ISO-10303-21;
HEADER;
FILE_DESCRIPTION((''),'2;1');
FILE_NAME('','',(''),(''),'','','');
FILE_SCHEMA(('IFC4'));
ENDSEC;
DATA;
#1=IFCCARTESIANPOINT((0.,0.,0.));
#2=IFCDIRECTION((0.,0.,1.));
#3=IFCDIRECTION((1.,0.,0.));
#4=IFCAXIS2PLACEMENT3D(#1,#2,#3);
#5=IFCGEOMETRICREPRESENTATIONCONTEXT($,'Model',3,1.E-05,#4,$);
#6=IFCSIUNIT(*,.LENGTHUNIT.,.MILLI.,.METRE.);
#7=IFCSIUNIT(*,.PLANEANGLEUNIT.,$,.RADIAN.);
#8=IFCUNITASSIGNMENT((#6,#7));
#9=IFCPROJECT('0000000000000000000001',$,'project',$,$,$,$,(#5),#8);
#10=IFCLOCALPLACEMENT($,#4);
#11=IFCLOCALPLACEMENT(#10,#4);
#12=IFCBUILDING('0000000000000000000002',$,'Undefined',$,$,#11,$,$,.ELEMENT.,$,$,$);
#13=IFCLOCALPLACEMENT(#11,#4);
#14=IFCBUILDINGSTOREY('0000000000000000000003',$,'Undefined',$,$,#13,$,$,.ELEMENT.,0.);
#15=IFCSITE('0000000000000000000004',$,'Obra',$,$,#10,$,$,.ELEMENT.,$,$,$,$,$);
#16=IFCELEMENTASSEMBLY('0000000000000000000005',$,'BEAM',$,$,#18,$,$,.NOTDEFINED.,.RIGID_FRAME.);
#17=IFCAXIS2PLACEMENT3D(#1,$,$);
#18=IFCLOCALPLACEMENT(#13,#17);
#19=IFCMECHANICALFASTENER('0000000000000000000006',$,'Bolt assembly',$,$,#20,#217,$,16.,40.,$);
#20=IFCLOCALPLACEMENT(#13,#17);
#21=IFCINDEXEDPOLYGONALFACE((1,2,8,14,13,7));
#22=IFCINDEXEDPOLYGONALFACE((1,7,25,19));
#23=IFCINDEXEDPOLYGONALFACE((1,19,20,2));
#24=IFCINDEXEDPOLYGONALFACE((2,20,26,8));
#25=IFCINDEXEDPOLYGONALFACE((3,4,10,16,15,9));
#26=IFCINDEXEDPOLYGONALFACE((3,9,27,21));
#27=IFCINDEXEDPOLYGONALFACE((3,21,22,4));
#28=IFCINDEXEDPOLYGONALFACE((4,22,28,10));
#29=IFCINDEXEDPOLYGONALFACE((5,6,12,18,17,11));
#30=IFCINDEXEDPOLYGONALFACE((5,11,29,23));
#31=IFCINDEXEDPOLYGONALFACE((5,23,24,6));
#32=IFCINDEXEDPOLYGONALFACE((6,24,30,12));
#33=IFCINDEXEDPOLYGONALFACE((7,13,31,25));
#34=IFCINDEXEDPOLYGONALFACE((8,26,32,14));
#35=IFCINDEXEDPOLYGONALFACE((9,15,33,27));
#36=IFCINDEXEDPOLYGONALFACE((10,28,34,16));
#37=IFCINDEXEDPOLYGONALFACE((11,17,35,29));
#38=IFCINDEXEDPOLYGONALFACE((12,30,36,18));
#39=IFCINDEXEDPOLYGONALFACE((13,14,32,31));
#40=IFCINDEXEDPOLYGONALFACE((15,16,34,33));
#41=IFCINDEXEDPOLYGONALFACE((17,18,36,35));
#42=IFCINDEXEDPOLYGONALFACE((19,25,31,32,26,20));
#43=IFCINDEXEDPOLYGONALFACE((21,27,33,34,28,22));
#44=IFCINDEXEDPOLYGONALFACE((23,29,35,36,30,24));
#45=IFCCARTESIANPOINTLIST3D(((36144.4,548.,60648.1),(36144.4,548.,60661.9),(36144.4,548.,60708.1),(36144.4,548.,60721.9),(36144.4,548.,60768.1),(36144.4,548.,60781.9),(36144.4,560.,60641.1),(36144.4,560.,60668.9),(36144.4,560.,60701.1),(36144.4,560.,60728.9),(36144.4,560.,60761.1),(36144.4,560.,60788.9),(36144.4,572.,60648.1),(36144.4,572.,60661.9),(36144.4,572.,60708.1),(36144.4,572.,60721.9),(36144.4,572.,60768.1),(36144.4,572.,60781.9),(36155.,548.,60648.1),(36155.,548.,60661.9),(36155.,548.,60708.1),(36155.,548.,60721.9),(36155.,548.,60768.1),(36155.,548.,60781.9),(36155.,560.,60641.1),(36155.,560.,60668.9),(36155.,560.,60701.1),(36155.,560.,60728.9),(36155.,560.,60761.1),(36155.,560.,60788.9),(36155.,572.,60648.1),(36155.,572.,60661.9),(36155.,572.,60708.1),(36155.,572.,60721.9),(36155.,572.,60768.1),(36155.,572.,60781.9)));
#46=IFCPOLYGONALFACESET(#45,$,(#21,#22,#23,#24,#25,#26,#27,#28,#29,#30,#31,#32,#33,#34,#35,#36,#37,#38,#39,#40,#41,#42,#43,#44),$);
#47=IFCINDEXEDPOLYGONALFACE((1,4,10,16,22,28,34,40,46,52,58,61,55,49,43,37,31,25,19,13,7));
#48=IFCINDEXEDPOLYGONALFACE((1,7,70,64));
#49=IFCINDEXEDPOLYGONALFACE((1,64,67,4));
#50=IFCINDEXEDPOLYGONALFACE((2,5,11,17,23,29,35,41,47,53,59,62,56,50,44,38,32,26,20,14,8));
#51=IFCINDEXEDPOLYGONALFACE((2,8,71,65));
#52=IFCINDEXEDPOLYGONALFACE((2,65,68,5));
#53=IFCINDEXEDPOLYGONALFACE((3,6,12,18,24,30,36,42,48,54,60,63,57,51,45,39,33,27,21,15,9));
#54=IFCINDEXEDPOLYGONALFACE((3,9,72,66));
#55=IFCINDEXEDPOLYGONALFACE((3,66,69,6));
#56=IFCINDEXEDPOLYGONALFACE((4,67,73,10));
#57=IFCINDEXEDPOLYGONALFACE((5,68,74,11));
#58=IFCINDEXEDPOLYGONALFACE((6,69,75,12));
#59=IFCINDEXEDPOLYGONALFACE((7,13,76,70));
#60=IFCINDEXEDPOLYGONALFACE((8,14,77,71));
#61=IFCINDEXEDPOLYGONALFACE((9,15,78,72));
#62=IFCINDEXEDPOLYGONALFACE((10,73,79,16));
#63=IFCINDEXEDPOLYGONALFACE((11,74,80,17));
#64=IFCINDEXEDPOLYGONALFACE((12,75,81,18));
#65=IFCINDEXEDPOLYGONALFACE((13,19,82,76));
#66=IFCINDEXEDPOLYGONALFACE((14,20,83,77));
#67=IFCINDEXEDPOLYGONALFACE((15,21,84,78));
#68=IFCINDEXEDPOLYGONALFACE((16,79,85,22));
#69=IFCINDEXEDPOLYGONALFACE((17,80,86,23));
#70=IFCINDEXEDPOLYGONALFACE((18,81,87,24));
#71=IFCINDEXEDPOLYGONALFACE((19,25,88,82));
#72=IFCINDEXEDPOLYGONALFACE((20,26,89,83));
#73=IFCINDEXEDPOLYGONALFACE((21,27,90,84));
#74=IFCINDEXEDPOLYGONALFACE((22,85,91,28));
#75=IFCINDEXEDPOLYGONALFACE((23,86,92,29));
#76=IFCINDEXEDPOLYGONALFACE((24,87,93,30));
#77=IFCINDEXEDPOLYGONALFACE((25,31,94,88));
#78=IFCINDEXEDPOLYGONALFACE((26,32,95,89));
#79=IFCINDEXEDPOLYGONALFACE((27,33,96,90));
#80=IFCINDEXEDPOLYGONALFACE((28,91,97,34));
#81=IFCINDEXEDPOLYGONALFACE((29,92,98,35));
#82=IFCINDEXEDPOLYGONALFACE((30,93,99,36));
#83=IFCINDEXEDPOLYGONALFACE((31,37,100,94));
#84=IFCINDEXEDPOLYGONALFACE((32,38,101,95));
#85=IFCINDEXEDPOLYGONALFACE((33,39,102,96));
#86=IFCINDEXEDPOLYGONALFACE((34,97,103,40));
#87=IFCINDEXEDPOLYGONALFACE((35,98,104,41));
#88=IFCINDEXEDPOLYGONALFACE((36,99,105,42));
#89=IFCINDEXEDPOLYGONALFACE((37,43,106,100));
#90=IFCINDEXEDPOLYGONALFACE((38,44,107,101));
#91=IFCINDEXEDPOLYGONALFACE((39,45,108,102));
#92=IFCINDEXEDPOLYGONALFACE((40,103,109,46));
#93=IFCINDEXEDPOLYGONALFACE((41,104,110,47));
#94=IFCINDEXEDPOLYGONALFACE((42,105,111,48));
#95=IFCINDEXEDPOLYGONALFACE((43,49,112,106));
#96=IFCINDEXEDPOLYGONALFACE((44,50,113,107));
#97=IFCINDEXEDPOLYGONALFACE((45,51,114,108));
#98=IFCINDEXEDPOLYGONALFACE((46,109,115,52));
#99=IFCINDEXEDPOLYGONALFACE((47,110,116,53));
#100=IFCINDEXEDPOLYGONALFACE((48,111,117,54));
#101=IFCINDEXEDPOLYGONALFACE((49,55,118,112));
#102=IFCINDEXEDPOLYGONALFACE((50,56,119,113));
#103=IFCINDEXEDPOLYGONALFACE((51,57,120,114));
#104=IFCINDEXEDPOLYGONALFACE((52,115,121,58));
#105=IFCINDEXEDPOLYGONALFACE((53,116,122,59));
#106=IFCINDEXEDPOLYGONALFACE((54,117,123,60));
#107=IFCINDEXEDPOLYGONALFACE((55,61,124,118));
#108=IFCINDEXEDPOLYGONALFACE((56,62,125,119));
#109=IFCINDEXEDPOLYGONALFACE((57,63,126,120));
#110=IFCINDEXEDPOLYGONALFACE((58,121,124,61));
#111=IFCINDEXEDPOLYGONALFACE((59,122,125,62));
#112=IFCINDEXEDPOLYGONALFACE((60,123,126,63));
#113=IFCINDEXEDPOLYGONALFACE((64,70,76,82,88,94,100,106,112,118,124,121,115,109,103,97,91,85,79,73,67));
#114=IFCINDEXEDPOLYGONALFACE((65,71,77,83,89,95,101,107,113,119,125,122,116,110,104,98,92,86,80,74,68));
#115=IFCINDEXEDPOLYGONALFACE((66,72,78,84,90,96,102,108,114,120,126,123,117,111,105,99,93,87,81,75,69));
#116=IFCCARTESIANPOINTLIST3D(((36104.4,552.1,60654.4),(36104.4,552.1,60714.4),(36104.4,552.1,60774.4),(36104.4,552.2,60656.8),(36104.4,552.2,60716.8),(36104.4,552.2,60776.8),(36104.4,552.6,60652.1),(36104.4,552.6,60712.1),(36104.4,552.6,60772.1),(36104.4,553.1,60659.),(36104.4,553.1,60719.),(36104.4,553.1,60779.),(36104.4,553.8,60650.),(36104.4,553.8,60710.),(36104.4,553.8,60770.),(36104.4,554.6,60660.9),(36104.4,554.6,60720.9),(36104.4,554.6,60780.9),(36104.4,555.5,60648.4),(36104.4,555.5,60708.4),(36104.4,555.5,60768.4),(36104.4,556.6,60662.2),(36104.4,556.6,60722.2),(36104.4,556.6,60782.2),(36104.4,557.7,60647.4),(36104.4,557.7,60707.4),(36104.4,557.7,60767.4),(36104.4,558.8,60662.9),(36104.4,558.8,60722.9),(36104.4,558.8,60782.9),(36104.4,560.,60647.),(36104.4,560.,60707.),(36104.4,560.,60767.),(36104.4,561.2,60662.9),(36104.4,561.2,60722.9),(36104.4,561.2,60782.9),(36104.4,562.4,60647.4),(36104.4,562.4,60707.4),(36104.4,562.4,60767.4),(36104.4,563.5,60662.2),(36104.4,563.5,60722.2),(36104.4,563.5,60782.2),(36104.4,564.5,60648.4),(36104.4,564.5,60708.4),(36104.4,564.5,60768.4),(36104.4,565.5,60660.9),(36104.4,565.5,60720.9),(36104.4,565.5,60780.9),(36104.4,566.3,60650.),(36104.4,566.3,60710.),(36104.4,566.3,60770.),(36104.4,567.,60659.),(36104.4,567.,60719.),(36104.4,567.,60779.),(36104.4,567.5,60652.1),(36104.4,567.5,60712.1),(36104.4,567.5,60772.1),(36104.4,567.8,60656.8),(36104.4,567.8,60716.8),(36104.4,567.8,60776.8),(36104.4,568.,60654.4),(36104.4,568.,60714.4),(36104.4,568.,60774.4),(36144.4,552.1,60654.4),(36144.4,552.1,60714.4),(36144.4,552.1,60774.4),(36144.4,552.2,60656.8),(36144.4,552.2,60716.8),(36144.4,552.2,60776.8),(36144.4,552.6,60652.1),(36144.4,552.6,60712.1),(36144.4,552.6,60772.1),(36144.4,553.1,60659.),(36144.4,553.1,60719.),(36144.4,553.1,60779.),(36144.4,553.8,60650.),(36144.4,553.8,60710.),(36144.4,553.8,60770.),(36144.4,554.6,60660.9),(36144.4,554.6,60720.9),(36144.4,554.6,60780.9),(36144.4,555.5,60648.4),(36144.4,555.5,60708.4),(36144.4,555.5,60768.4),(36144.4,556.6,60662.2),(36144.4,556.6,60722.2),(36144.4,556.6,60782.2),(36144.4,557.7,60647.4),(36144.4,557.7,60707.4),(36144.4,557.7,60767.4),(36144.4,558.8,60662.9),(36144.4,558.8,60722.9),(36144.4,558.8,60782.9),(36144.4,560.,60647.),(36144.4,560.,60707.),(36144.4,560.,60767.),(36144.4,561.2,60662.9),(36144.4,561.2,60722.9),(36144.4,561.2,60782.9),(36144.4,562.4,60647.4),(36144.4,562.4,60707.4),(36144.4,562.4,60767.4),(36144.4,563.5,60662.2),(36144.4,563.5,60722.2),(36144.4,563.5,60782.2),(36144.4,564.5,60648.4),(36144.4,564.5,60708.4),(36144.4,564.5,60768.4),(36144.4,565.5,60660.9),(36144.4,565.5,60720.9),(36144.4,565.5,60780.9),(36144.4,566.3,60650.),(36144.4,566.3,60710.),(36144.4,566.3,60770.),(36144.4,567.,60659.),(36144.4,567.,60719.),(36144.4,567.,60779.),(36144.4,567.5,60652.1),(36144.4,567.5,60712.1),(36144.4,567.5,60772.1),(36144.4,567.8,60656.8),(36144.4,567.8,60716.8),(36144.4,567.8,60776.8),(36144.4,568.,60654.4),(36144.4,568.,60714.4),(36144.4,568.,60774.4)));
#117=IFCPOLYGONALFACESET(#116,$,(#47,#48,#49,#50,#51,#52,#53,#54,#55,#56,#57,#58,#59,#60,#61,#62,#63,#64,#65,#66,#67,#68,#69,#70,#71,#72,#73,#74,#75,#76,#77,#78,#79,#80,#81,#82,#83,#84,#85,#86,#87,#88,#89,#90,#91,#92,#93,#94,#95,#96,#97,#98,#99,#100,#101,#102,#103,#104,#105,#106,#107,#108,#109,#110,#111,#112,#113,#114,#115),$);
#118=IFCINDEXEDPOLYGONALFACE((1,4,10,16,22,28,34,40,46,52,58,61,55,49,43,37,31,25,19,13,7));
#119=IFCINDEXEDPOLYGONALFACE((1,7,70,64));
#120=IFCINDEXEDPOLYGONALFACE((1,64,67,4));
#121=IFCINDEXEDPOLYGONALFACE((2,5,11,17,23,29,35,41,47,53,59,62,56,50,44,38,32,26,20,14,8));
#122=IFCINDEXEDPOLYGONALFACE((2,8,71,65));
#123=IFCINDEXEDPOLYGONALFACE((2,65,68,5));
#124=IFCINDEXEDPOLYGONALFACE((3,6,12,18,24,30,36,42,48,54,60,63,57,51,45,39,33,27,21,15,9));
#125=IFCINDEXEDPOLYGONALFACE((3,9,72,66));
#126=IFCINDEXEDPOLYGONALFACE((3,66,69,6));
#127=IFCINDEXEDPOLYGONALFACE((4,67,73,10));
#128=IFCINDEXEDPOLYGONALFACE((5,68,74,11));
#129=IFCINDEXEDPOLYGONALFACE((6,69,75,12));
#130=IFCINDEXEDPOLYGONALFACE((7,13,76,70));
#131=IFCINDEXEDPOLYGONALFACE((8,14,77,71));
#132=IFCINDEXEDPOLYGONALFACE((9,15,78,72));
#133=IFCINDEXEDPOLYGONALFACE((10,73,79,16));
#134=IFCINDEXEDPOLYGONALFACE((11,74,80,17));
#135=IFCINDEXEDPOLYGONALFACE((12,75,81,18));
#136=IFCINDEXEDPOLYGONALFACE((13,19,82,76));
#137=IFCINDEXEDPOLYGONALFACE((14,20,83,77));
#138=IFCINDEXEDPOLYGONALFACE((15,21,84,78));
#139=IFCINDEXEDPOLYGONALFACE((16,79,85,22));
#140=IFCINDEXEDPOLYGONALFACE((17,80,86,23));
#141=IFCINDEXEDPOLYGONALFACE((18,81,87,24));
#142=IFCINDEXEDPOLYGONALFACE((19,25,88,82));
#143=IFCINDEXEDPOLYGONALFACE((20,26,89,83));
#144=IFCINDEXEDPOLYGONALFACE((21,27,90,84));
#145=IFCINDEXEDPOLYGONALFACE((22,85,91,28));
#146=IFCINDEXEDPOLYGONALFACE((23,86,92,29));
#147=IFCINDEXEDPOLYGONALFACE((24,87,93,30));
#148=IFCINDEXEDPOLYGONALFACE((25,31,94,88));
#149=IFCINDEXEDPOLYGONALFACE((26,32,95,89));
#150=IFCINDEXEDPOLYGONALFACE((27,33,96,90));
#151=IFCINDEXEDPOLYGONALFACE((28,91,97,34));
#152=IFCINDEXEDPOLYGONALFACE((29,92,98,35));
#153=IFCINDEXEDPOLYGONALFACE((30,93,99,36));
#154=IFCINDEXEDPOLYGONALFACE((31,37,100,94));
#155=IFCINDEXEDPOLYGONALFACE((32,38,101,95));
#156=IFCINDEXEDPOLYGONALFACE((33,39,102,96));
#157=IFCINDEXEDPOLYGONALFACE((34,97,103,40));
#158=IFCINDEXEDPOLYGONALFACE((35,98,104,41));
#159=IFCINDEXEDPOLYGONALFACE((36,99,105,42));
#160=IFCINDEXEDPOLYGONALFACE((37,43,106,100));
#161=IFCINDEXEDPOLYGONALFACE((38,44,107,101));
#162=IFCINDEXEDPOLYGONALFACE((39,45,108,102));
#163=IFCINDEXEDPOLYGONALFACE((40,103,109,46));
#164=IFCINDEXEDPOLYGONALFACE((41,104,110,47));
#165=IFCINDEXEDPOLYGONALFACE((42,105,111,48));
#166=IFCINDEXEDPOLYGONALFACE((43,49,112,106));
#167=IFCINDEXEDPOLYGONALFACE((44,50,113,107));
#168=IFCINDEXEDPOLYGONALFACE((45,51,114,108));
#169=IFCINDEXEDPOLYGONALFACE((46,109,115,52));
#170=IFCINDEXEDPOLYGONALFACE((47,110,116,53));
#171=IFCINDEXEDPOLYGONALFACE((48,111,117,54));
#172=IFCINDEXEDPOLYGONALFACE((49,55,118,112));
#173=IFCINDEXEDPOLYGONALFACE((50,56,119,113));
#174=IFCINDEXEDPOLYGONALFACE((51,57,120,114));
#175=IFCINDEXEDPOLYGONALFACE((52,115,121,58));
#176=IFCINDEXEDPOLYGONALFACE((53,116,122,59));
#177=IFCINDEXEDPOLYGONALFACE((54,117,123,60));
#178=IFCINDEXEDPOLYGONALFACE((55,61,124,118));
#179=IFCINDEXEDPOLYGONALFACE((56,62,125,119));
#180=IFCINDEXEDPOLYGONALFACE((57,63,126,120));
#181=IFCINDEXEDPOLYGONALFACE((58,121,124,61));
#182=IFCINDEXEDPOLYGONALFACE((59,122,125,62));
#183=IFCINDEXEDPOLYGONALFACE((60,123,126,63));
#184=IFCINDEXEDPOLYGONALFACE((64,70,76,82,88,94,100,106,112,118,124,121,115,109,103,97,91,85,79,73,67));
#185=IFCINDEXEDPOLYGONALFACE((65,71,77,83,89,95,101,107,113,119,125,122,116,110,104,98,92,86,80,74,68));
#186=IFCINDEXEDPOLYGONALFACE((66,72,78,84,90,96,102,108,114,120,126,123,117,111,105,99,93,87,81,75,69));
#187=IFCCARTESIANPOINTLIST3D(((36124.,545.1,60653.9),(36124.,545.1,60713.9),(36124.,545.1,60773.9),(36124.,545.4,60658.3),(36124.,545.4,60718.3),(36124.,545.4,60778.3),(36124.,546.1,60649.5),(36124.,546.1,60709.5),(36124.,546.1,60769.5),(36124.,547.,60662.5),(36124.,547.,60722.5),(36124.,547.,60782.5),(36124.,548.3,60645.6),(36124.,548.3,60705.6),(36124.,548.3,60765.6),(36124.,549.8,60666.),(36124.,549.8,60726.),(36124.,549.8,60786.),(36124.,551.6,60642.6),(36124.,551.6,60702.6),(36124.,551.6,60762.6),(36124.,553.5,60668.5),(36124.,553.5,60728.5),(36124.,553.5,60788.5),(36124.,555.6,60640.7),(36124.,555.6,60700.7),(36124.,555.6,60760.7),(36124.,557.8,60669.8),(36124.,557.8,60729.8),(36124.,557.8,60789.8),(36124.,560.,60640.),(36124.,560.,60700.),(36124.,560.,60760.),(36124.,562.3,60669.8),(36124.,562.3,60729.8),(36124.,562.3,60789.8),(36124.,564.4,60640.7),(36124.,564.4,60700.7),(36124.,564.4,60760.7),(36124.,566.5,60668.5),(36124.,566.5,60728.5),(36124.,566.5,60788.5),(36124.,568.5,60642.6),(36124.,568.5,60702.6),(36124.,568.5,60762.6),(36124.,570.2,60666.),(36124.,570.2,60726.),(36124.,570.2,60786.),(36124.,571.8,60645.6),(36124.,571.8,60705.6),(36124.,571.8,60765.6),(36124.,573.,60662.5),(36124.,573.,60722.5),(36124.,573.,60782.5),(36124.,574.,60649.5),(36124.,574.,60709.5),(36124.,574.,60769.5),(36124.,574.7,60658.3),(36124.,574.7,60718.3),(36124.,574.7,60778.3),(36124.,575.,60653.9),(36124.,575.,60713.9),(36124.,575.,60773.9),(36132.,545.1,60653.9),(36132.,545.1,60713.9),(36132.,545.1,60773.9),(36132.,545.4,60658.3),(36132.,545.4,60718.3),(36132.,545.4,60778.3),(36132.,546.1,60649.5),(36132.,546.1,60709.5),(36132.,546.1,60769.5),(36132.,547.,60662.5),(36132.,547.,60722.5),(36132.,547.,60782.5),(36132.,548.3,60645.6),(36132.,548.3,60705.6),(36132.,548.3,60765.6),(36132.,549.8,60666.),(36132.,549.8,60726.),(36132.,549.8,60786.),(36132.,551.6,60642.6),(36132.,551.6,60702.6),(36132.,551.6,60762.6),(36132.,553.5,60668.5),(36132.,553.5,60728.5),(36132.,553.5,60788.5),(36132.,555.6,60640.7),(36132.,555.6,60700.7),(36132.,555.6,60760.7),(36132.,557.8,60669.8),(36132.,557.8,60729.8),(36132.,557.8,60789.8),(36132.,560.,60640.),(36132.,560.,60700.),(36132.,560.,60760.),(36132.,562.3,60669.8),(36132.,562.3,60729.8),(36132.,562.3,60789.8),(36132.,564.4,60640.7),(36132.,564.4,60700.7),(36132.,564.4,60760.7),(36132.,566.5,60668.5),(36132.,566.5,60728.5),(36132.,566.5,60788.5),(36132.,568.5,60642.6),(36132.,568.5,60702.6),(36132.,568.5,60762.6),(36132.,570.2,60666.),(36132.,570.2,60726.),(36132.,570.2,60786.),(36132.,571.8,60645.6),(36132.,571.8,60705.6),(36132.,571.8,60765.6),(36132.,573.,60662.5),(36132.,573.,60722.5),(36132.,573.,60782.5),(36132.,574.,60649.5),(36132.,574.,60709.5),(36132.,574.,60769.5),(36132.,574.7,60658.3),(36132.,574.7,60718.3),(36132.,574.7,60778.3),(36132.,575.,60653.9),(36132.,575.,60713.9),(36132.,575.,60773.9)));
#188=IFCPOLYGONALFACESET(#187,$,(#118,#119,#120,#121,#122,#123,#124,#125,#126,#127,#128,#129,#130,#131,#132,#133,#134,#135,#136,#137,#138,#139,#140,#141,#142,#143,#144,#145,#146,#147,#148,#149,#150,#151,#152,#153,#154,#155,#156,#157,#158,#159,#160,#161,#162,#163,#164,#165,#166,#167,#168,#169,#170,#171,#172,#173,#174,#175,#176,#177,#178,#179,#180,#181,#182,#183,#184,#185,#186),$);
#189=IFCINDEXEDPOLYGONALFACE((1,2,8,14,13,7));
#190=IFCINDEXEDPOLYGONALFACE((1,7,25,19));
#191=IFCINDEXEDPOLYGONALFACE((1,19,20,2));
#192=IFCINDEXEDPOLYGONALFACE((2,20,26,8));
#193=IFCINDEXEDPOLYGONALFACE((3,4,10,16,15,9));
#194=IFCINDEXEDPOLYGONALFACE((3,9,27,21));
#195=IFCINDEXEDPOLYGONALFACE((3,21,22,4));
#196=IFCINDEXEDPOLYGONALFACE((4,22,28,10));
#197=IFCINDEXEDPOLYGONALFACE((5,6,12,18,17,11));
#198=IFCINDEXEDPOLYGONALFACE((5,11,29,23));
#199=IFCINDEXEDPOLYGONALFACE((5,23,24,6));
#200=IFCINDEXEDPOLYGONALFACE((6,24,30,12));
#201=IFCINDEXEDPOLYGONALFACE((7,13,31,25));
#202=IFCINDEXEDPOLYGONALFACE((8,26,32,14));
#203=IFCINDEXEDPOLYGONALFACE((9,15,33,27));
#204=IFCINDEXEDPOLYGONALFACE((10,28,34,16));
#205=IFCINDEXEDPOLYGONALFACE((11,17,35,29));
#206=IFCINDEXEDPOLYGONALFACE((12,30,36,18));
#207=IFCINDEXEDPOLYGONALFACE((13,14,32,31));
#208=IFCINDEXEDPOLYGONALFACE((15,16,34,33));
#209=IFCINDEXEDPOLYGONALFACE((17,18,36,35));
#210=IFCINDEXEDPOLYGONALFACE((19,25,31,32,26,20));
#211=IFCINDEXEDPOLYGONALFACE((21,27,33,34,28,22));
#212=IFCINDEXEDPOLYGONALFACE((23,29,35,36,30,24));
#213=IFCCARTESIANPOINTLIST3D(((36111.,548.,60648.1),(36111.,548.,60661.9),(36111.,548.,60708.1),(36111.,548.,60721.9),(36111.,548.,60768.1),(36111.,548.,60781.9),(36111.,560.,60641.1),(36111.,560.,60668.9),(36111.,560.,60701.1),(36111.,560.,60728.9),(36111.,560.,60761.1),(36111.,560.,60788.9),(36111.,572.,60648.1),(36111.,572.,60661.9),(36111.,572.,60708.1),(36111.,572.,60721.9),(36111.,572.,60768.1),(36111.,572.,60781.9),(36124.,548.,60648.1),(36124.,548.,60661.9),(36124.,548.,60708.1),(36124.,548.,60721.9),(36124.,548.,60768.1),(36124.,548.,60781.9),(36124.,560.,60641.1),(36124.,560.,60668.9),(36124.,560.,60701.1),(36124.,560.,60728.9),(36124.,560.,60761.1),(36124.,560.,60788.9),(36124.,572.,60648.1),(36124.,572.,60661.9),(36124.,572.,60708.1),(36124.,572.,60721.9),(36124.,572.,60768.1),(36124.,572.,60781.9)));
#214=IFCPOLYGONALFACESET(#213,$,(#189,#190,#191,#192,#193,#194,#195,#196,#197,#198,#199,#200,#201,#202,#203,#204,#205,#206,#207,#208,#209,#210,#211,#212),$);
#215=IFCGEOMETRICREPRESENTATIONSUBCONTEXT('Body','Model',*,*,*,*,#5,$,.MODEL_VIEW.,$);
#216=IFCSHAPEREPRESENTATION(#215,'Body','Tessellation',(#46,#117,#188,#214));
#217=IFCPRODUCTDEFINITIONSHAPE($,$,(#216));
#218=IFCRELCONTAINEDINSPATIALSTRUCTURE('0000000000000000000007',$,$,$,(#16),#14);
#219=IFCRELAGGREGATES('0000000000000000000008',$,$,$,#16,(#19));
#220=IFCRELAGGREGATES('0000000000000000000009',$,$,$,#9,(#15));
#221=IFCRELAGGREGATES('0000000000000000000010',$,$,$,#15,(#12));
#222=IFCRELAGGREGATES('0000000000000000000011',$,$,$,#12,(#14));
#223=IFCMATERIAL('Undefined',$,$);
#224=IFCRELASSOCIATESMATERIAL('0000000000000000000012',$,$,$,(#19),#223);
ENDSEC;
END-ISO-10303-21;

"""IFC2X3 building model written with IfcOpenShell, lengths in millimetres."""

from ifc_helpers import new_model, si_unit, frame, origin_with_axes, origin_2d_with_axis, place, context, subcontext, project, spatial, polyline, circle, outline, extrude, source, transform, mapped, material, element, aggregate, save


model = new_model("IFC2X3")

# Units and contexts
model_context = context("Model", 3, precision=1e-05, world=origin_with_axes())
body_context = subcontext(model_context, "Body", "Model", "MODEL_VIEW")
ifc_project = project(units=[si_unit("LENGTHUNIT", "METRE", prefix="MILLI"), si_unit("PLANEANGLEUNIT", "RADIAN")], contexts=[model_context])

# Site, building, storey
site_placement = place(None, origin_with_axes())
site = spatial("IfcSite", under=ifc_project, at=site_placement, Name="Obra", CompositionType="ELEMENT")
building_placement = place(site_placement, origin_with_axes())
building = spatial("IfcBuilding", under=site, at=building_placement, Name="Undefined", CompositionType="ELEMENT")
storey_placement = place(building_placement, origin_with_axes())
storey = spatial("IfcBuildingStorey", under=building, at=storey_placement, Name="Undefined", CompositionType="ELEMENT", Elevation=0.0)

# Element assembly
ifc_material_1 = material(Name="Undefined")
assembly_1_placement = place(storey_placement, origin_with_axes())
assembly_1 = element("IfcElementAssembly", 1, at=assembly_1_placement, inside=storey, Name="BEAM", AssemblyPlace="NOTDEFINED", PredefinedType="RIGID_FRAME")

# Mechanical fastener
shared_shape_1 = source(origin_with_axes(), body_context, "Body", "SweptSolid", [
    extrude(outline(polyline([(13.9, 0.0), (6.9, 12.0), (-6.9, 12.0), (-13.9, 0.0), (-6.9, -12.0), (6.9, -12.0), (13.9, 0.0)])), frame((0.0, -19.7, 0.0), z_axis=(0.0, 1.0, 0.0), x_axis=(1.0, 0.0, 0.0)), (0.0, 0.0, 1.0), 10.6),
    extrude(circle(Radius=8.0, at=origin_2d_with_axis()), frame((0.0, -9.1, 0.0), z_axis=(0.0, 1.0, 0.0), x_axis=(1.0, 0.0, 0.0)), (0.0, 0.0, 1.0), 40.0),
    extrude(circle(Radius=15.0, at=origin_2d_with_axis()), frame((0.0, 3.3, 0.0), z_axis=(0.0, 1.0, 0.0), x_axis=(1.0, 0.0, 0.0)), (0.0, 0.0, 1.0), 8.0),
    extrude(outline(polyline([(13.9, 0.0), (6.9, 12.0), (-6.9, 12.0), (-13.9, 0.0), (-6.9, -12.0), (6.9, -12.0), (13.9, 0.0)])), frame((0.0, 11.3, 0.0), z_axis=(0.0, 1.0, 0.0), x_axis=(1.0, 0.0, 0.0)), (0.0, 0.0, 1.0), 13.0),
])
mechanical_fastener_1_placement = place(assembly_1_placement, frame((36135.3, 510.0, 60835.0), z_axis=(-0.000002, 1.0, 0.0), x_axis=(0.0, 0.0, -1.0)))
mechanical_fastener_1 = element("IfcMechanicalFastener", 2, at=mechanical_fastener_1_placement, material=ifc_material_1, Name="Bolt assembly", NominalDiameter=16.0, NominalLength=40.0, context=body_context, shape_type="MappedRepresentation", body=[
    mapped(shared_shape_1, transform((60.0, 0.0, 50.0))),
    mapped(shared_shape_1, transform((120.0, 0.0, 50.0))),
    mapped(shared_shape_1, transform((180.0, 0.0, 50.0))),
])
aggregate(assembly_1, [mechanical_fastener_1])

save(model, "model.ifc")
